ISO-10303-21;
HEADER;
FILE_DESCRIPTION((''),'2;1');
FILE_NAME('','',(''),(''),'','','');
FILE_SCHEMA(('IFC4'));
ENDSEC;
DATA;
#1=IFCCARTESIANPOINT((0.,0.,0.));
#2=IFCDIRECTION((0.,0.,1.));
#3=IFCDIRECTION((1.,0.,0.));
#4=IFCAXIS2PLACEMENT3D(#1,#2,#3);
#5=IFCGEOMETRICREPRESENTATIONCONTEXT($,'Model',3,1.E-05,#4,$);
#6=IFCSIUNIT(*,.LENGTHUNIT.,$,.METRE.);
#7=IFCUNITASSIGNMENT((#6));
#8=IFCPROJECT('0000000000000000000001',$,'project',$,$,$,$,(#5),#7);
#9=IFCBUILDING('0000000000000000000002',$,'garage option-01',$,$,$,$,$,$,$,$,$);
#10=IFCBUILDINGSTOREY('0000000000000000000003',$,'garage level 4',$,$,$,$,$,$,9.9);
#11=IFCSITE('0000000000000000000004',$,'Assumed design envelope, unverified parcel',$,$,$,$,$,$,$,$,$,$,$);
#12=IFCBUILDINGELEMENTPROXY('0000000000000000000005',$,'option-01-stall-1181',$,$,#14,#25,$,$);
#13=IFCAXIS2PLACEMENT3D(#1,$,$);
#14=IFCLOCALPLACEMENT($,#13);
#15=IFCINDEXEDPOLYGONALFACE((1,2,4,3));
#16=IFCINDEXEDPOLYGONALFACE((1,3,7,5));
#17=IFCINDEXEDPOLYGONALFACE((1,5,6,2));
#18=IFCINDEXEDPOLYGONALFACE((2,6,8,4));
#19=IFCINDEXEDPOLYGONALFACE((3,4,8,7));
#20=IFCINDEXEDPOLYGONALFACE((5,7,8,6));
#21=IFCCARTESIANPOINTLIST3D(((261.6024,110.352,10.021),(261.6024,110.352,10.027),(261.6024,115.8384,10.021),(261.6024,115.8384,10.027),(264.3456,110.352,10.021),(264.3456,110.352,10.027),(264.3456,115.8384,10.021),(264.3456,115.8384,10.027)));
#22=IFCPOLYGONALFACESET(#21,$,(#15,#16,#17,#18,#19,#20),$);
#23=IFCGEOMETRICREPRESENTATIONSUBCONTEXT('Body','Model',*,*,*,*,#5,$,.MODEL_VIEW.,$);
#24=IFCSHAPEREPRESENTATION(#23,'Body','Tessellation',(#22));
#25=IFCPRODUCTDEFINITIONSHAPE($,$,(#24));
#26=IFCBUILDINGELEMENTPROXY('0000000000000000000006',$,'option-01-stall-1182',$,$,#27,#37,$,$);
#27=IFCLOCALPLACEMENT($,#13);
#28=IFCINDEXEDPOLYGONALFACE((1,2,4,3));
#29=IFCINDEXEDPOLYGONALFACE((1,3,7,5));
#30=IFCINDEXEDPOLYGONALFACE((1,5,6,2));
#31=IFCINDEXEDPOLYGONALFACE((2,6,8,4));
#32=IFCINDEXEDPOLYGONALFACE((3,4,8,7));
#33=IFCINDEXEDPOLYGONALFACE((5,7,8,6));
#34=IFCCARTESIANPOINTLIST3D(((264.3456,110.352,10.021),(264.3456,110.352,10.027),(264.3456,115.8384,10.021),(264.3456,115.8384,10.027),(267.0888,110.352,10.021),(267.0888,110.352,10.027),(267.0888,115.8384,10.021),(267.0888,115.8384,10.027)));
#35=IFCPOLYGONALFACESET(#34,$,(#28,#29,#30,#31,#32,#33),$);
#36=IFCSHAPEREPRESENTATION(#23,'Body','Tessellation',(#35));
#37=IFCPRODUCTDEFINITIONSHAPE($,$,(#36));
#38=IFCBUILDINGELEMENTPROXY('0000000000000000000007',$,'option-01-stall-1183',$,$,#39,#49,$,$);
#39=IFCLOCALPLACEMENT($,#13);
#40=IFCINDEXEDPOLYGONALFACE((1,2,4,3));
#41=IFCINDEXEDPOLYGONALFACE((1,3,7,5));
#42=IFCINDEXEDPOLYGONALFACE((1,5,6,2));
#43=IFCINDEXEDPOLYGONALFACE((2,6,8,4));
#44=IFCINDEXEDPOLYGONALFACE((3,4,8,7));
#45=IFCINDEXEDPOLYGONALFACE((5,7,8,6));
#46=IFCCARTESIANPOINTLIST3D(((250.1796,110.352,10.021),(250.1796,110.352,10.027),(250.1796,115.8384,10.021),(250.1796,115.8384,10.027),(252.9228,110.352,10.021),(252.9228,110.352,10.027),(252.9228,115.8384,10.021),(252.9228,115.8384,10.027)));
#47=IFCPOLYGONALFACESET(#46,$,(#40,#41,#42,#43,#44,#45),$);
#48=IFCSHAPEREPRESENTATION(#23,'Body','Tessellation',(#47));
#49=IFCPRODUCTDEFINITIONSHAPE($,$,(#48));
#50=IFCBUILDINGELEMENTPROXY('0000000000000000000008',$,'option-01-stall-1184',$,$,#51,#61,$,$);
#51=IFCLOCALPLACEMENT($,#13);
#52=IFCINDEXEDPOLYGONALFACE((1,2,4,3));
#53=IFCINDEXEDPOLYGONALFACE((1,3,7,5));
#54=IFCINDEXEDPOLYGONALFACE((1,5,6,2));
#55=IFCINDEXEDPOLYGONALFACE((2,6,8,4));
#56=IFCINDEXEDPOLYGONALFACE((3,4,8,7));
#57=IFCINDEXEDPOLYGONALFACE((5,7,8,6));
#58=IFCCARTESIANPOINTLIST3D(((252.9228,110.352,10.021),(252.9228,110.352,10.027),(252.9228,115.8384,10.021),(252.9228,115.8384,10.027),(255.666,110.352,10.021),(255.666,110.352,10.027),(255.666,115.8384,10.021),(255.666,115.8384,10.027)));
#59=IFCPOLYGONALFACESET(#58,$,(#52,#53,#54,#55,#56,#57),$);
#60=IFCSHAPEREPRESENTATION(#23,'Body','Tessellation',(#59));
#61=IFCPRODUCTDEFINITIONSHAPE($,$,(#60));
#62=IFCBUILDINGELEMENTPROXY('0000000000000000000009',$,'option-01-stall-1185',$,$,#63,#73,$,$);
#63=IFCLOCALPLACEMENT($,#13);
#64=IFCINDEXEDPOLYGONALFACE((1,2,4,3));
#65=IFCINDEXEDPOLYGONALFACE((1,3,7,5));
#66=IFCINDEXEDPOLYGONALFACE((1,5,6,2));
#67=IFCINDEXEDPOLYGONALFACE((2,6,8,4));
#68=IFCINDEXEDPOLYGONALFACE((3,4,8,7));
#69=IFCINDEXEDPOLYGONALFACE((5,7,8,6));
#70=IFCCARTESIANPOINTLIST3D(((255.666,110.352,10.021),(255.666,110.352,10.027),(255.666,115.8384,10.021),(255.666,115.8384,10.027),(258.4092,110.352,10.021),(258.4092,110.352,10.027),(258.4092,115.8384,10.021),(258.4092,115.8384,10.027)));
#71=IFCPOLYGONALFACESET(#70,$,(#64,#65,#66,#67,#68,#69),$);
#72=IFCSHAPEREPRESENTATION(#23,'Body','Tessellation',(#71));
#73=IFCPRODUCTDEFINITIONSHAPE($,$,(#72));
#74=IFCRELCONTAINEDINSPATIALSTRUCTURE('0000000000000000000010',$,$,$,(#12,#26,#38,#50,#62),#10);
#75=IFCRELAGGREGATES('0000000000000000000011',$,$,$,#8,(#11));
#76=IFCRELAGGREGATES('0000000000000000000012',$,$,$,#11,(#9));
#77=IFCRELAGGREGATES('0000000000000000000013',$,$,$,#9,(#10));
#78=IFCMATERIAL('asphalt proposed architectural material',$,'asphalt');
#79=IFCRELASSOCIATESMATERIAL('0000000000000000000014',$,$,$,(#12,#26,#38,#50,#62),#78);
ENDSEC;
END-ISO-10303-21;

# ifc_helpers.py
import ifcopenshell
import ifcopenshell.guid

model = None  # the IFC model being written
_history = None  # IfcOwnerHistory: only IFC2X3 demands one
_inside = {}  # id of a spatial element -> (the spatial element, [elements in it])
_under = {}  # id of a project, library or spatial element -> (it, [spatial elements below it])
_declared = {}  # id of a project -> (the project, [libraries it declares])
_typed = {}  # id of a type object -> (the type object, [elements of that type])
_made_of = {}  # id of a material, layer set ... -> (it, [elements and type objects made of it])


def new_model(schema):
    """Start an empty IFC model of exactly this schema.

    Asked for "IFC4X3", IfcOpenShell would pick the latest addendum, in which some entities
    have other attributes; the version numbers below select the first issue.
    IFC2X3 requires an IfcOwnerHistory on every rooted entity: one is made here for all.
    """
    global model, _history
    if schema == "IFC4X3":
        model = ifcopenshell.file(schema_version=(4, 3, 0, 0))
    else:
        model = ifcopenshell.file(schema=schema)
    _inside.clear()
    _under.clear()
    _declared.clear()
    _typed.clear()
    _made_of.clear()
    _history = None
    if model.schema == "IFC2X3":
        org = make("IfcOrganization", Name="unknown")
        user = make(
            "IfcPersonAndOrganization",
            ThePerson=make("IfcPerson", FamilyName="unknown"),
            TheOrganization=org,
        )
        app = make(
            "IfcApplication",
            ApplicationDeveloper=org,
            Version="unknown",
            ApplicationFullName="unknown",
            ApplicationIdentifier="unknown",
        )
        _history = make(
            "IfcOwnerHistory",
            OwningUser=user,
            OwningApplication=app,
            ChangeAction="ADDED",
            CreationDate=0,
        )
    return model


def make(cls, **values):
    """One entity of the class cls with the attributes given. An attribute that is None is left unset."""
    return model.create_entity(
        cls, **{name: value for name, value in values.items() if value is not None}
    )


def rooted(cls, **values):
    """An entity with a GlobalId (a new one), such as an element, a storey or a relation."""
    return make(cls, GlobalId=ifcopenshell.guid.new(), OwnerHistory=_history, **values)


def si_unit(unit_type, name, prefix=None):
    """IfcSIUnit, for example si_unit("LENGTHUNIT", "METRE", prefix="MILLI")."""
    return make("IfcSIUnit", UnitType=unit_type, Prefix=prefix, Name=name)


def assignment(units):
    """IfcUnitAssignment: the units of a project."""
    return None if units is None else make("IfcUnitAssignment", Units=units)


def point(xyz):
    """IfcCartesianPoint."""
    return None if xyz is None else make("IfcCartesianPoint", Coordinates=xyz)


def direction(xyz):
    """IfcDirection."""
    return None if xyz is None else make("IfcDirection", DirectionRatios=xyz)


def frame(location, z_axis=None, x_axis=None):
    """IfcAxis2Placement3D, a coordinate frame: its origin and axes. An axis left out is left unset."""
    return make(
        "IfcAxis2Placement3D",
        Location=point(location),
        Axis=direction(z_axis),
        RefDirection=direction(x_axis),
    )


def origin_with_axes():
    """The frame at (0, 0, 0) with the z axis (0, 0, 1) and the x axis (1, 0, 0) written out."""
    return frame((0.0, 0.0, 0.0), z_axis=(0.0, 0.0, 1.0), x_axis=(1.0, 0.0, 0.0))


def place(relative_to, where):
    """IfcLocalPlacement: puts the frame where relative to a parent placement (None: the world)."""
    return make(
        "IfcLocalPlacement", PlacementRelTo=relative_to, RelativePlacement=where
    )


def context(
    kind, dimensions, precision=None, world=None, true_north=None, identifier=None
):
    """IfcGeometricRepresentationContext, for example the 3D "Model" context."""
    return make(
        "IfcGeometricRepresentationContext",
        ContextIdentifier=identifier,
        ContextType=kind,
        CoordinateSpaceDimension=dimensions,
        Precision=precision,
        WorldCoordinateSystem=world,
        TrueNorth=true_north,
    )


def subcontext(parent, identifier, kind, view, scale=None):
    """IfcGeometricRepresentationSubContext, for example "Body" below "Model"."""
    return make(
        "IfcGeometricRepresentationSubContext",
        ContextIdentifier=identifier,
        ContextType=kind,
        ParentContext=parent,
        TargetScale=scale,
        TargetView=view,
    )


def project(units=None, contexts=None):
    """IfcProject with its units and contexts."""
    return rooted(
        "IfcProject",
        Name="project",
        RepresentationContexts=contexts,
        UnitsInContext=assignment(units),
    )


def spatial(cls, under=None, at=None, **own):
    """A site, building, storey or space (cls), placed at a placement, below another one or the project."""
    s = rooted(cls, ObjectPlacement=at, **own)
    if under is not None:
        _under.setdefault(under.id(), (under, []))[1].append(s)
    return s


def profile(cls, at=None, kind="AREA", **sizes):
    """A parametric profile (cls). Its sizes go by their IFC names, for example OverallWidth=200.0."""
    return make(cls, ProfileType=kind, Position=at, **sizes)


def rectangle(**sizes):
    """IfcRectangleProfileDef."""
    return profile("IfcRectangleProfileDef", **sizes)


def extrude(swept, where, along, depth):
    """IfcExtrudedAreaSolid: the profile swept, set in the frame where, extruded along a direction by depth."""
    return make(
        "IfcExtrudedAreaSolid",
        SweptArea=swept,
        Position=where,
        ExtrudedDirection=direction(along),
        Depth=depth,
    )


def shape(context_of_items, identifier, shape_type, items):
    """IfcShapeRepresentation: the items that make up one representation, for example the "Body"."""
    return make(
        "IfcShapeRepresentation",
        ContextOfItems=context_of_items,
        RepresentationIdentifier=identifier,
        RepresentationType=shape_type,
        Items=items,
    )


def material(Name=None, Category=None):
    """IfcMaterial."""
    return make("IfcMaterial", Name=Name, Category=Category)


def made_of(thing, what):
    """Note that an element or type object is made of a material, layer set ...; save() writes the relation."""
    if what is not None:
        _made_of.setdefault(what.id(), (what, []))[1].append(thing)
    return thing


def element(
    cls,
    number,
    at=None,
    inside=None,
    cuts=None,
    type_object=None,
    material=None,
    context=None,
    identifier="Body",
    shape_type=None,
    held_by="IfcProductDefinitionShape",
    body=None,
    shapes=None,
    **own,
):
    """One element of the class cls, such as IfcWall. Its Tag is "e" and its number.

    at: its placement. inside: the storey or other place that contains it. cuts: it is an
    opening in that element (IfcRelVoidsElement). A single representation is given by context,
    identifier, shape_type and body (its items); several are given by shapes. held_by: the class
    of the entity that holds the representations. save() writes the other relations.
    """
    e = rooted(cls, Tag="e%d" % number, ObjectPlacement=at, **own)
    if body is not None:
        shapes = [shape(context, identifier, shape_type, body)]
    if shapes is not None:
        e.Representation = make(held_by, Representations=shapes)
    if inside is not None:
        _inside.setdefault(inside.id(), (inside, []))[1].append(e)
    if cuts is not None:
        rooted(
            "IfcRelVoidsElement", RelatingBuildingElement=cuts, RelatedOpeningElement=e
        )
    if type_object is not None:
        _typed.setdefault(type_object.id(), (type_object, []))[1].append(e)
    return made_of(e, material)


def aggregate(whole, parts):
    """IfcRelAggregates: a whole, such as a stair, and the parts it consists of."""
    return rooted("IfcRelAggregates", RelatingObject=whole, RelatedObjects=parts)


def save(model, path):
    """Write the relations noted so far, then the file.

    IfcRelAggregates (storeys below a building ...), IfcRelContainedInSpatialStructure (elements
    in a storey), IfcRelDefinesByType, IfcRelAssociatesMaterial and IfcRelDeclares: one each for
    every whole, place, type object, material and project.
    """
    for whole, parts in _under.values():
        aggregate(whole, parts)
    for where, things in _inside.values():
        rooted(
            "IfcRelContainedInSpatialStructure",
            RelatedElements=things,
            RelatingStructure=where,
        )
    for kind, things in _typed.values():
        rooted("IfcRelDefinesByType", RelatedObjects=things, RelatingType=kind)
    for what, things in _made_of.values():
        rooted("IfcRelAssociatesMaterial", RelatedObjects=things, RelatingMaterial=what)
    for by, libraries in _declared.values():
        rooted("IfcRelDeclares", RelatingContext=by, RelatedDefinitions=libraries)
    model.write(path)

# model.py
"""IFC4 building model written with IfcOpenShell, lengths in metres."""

from ifc_helpers import new_model, si_unit, frame, origin_with_axes, place, context, subcontext, project, spatial, rectangle, extrude, material, element, save


model = new_model("IFC4")

# Units and contexts
model_context = context("Model", 3, precision=1e-05, world=origin_with_axes())
body_context = subcontext(model_context, "Body", "Model", "MODEL_VIEW")
ifc_project = project(units=[si_unit("LENGTHUNIT", "METRE")], contexts=[model_context])

# Site, building, storey
site = spatial("IfcSite", under=ifc_project, Name="Assumed design envelope, unverified parcel")
building = spatial("IfcBuilding", under=site, Name="garage option-01")
storey = spatial("IfcBuildingStorey", under=building, Name="garage level 4", Elevation=9.9)

# Building element proxies
ifc_material_1 = material(Name="asphalt proposed architectural material", Category="asphalt")
for number, where, z_axis, x_axis, name in (
    (1, (262.974, 113.0952, 10.021), (0.0, 0.0, 1.0), (1.0, 0.0, 0.0), "option-01-stall-1181"),
    (2, (265.7172, 113.0952, 10.021), (0.0, 0.0, 1.0), (1.0, 0.0, 0.0), "option-01-stall-1182"),
    (3, (251.5512, 113.0952, 10.021), (0.0, 0.0, 1.0), (1.0, 0.0, 0.0), "option-01-stall-1183"),
    (4, (254.2944, 113.0952, 10.021), (0.0, 0.0, 1.0), (1.0, 0.0, 0.0), "option-01-stall-1184"),
    (5, (257.0376, 113.0952, 10.021), (0.0, 0.0, 1.0), (1.0, 0.0, 0.0), "option-01-stall-1185"),
):
    element("IfcBuildingElementProxy", number, at=place(None, frame(where, z_axis=z_axis, x_axis=x_axis)), inside=storey, material=ifc_material_1, Name=name, context=body_context, shape_type="SweptSolid", body=[
        extrude(rectangle(XDim=2.7432, YDim=5.4864), origin_with_axes(), (0.0, 0.0, 1.0), 0.006),
    ])

save(model, "model.ifc")
